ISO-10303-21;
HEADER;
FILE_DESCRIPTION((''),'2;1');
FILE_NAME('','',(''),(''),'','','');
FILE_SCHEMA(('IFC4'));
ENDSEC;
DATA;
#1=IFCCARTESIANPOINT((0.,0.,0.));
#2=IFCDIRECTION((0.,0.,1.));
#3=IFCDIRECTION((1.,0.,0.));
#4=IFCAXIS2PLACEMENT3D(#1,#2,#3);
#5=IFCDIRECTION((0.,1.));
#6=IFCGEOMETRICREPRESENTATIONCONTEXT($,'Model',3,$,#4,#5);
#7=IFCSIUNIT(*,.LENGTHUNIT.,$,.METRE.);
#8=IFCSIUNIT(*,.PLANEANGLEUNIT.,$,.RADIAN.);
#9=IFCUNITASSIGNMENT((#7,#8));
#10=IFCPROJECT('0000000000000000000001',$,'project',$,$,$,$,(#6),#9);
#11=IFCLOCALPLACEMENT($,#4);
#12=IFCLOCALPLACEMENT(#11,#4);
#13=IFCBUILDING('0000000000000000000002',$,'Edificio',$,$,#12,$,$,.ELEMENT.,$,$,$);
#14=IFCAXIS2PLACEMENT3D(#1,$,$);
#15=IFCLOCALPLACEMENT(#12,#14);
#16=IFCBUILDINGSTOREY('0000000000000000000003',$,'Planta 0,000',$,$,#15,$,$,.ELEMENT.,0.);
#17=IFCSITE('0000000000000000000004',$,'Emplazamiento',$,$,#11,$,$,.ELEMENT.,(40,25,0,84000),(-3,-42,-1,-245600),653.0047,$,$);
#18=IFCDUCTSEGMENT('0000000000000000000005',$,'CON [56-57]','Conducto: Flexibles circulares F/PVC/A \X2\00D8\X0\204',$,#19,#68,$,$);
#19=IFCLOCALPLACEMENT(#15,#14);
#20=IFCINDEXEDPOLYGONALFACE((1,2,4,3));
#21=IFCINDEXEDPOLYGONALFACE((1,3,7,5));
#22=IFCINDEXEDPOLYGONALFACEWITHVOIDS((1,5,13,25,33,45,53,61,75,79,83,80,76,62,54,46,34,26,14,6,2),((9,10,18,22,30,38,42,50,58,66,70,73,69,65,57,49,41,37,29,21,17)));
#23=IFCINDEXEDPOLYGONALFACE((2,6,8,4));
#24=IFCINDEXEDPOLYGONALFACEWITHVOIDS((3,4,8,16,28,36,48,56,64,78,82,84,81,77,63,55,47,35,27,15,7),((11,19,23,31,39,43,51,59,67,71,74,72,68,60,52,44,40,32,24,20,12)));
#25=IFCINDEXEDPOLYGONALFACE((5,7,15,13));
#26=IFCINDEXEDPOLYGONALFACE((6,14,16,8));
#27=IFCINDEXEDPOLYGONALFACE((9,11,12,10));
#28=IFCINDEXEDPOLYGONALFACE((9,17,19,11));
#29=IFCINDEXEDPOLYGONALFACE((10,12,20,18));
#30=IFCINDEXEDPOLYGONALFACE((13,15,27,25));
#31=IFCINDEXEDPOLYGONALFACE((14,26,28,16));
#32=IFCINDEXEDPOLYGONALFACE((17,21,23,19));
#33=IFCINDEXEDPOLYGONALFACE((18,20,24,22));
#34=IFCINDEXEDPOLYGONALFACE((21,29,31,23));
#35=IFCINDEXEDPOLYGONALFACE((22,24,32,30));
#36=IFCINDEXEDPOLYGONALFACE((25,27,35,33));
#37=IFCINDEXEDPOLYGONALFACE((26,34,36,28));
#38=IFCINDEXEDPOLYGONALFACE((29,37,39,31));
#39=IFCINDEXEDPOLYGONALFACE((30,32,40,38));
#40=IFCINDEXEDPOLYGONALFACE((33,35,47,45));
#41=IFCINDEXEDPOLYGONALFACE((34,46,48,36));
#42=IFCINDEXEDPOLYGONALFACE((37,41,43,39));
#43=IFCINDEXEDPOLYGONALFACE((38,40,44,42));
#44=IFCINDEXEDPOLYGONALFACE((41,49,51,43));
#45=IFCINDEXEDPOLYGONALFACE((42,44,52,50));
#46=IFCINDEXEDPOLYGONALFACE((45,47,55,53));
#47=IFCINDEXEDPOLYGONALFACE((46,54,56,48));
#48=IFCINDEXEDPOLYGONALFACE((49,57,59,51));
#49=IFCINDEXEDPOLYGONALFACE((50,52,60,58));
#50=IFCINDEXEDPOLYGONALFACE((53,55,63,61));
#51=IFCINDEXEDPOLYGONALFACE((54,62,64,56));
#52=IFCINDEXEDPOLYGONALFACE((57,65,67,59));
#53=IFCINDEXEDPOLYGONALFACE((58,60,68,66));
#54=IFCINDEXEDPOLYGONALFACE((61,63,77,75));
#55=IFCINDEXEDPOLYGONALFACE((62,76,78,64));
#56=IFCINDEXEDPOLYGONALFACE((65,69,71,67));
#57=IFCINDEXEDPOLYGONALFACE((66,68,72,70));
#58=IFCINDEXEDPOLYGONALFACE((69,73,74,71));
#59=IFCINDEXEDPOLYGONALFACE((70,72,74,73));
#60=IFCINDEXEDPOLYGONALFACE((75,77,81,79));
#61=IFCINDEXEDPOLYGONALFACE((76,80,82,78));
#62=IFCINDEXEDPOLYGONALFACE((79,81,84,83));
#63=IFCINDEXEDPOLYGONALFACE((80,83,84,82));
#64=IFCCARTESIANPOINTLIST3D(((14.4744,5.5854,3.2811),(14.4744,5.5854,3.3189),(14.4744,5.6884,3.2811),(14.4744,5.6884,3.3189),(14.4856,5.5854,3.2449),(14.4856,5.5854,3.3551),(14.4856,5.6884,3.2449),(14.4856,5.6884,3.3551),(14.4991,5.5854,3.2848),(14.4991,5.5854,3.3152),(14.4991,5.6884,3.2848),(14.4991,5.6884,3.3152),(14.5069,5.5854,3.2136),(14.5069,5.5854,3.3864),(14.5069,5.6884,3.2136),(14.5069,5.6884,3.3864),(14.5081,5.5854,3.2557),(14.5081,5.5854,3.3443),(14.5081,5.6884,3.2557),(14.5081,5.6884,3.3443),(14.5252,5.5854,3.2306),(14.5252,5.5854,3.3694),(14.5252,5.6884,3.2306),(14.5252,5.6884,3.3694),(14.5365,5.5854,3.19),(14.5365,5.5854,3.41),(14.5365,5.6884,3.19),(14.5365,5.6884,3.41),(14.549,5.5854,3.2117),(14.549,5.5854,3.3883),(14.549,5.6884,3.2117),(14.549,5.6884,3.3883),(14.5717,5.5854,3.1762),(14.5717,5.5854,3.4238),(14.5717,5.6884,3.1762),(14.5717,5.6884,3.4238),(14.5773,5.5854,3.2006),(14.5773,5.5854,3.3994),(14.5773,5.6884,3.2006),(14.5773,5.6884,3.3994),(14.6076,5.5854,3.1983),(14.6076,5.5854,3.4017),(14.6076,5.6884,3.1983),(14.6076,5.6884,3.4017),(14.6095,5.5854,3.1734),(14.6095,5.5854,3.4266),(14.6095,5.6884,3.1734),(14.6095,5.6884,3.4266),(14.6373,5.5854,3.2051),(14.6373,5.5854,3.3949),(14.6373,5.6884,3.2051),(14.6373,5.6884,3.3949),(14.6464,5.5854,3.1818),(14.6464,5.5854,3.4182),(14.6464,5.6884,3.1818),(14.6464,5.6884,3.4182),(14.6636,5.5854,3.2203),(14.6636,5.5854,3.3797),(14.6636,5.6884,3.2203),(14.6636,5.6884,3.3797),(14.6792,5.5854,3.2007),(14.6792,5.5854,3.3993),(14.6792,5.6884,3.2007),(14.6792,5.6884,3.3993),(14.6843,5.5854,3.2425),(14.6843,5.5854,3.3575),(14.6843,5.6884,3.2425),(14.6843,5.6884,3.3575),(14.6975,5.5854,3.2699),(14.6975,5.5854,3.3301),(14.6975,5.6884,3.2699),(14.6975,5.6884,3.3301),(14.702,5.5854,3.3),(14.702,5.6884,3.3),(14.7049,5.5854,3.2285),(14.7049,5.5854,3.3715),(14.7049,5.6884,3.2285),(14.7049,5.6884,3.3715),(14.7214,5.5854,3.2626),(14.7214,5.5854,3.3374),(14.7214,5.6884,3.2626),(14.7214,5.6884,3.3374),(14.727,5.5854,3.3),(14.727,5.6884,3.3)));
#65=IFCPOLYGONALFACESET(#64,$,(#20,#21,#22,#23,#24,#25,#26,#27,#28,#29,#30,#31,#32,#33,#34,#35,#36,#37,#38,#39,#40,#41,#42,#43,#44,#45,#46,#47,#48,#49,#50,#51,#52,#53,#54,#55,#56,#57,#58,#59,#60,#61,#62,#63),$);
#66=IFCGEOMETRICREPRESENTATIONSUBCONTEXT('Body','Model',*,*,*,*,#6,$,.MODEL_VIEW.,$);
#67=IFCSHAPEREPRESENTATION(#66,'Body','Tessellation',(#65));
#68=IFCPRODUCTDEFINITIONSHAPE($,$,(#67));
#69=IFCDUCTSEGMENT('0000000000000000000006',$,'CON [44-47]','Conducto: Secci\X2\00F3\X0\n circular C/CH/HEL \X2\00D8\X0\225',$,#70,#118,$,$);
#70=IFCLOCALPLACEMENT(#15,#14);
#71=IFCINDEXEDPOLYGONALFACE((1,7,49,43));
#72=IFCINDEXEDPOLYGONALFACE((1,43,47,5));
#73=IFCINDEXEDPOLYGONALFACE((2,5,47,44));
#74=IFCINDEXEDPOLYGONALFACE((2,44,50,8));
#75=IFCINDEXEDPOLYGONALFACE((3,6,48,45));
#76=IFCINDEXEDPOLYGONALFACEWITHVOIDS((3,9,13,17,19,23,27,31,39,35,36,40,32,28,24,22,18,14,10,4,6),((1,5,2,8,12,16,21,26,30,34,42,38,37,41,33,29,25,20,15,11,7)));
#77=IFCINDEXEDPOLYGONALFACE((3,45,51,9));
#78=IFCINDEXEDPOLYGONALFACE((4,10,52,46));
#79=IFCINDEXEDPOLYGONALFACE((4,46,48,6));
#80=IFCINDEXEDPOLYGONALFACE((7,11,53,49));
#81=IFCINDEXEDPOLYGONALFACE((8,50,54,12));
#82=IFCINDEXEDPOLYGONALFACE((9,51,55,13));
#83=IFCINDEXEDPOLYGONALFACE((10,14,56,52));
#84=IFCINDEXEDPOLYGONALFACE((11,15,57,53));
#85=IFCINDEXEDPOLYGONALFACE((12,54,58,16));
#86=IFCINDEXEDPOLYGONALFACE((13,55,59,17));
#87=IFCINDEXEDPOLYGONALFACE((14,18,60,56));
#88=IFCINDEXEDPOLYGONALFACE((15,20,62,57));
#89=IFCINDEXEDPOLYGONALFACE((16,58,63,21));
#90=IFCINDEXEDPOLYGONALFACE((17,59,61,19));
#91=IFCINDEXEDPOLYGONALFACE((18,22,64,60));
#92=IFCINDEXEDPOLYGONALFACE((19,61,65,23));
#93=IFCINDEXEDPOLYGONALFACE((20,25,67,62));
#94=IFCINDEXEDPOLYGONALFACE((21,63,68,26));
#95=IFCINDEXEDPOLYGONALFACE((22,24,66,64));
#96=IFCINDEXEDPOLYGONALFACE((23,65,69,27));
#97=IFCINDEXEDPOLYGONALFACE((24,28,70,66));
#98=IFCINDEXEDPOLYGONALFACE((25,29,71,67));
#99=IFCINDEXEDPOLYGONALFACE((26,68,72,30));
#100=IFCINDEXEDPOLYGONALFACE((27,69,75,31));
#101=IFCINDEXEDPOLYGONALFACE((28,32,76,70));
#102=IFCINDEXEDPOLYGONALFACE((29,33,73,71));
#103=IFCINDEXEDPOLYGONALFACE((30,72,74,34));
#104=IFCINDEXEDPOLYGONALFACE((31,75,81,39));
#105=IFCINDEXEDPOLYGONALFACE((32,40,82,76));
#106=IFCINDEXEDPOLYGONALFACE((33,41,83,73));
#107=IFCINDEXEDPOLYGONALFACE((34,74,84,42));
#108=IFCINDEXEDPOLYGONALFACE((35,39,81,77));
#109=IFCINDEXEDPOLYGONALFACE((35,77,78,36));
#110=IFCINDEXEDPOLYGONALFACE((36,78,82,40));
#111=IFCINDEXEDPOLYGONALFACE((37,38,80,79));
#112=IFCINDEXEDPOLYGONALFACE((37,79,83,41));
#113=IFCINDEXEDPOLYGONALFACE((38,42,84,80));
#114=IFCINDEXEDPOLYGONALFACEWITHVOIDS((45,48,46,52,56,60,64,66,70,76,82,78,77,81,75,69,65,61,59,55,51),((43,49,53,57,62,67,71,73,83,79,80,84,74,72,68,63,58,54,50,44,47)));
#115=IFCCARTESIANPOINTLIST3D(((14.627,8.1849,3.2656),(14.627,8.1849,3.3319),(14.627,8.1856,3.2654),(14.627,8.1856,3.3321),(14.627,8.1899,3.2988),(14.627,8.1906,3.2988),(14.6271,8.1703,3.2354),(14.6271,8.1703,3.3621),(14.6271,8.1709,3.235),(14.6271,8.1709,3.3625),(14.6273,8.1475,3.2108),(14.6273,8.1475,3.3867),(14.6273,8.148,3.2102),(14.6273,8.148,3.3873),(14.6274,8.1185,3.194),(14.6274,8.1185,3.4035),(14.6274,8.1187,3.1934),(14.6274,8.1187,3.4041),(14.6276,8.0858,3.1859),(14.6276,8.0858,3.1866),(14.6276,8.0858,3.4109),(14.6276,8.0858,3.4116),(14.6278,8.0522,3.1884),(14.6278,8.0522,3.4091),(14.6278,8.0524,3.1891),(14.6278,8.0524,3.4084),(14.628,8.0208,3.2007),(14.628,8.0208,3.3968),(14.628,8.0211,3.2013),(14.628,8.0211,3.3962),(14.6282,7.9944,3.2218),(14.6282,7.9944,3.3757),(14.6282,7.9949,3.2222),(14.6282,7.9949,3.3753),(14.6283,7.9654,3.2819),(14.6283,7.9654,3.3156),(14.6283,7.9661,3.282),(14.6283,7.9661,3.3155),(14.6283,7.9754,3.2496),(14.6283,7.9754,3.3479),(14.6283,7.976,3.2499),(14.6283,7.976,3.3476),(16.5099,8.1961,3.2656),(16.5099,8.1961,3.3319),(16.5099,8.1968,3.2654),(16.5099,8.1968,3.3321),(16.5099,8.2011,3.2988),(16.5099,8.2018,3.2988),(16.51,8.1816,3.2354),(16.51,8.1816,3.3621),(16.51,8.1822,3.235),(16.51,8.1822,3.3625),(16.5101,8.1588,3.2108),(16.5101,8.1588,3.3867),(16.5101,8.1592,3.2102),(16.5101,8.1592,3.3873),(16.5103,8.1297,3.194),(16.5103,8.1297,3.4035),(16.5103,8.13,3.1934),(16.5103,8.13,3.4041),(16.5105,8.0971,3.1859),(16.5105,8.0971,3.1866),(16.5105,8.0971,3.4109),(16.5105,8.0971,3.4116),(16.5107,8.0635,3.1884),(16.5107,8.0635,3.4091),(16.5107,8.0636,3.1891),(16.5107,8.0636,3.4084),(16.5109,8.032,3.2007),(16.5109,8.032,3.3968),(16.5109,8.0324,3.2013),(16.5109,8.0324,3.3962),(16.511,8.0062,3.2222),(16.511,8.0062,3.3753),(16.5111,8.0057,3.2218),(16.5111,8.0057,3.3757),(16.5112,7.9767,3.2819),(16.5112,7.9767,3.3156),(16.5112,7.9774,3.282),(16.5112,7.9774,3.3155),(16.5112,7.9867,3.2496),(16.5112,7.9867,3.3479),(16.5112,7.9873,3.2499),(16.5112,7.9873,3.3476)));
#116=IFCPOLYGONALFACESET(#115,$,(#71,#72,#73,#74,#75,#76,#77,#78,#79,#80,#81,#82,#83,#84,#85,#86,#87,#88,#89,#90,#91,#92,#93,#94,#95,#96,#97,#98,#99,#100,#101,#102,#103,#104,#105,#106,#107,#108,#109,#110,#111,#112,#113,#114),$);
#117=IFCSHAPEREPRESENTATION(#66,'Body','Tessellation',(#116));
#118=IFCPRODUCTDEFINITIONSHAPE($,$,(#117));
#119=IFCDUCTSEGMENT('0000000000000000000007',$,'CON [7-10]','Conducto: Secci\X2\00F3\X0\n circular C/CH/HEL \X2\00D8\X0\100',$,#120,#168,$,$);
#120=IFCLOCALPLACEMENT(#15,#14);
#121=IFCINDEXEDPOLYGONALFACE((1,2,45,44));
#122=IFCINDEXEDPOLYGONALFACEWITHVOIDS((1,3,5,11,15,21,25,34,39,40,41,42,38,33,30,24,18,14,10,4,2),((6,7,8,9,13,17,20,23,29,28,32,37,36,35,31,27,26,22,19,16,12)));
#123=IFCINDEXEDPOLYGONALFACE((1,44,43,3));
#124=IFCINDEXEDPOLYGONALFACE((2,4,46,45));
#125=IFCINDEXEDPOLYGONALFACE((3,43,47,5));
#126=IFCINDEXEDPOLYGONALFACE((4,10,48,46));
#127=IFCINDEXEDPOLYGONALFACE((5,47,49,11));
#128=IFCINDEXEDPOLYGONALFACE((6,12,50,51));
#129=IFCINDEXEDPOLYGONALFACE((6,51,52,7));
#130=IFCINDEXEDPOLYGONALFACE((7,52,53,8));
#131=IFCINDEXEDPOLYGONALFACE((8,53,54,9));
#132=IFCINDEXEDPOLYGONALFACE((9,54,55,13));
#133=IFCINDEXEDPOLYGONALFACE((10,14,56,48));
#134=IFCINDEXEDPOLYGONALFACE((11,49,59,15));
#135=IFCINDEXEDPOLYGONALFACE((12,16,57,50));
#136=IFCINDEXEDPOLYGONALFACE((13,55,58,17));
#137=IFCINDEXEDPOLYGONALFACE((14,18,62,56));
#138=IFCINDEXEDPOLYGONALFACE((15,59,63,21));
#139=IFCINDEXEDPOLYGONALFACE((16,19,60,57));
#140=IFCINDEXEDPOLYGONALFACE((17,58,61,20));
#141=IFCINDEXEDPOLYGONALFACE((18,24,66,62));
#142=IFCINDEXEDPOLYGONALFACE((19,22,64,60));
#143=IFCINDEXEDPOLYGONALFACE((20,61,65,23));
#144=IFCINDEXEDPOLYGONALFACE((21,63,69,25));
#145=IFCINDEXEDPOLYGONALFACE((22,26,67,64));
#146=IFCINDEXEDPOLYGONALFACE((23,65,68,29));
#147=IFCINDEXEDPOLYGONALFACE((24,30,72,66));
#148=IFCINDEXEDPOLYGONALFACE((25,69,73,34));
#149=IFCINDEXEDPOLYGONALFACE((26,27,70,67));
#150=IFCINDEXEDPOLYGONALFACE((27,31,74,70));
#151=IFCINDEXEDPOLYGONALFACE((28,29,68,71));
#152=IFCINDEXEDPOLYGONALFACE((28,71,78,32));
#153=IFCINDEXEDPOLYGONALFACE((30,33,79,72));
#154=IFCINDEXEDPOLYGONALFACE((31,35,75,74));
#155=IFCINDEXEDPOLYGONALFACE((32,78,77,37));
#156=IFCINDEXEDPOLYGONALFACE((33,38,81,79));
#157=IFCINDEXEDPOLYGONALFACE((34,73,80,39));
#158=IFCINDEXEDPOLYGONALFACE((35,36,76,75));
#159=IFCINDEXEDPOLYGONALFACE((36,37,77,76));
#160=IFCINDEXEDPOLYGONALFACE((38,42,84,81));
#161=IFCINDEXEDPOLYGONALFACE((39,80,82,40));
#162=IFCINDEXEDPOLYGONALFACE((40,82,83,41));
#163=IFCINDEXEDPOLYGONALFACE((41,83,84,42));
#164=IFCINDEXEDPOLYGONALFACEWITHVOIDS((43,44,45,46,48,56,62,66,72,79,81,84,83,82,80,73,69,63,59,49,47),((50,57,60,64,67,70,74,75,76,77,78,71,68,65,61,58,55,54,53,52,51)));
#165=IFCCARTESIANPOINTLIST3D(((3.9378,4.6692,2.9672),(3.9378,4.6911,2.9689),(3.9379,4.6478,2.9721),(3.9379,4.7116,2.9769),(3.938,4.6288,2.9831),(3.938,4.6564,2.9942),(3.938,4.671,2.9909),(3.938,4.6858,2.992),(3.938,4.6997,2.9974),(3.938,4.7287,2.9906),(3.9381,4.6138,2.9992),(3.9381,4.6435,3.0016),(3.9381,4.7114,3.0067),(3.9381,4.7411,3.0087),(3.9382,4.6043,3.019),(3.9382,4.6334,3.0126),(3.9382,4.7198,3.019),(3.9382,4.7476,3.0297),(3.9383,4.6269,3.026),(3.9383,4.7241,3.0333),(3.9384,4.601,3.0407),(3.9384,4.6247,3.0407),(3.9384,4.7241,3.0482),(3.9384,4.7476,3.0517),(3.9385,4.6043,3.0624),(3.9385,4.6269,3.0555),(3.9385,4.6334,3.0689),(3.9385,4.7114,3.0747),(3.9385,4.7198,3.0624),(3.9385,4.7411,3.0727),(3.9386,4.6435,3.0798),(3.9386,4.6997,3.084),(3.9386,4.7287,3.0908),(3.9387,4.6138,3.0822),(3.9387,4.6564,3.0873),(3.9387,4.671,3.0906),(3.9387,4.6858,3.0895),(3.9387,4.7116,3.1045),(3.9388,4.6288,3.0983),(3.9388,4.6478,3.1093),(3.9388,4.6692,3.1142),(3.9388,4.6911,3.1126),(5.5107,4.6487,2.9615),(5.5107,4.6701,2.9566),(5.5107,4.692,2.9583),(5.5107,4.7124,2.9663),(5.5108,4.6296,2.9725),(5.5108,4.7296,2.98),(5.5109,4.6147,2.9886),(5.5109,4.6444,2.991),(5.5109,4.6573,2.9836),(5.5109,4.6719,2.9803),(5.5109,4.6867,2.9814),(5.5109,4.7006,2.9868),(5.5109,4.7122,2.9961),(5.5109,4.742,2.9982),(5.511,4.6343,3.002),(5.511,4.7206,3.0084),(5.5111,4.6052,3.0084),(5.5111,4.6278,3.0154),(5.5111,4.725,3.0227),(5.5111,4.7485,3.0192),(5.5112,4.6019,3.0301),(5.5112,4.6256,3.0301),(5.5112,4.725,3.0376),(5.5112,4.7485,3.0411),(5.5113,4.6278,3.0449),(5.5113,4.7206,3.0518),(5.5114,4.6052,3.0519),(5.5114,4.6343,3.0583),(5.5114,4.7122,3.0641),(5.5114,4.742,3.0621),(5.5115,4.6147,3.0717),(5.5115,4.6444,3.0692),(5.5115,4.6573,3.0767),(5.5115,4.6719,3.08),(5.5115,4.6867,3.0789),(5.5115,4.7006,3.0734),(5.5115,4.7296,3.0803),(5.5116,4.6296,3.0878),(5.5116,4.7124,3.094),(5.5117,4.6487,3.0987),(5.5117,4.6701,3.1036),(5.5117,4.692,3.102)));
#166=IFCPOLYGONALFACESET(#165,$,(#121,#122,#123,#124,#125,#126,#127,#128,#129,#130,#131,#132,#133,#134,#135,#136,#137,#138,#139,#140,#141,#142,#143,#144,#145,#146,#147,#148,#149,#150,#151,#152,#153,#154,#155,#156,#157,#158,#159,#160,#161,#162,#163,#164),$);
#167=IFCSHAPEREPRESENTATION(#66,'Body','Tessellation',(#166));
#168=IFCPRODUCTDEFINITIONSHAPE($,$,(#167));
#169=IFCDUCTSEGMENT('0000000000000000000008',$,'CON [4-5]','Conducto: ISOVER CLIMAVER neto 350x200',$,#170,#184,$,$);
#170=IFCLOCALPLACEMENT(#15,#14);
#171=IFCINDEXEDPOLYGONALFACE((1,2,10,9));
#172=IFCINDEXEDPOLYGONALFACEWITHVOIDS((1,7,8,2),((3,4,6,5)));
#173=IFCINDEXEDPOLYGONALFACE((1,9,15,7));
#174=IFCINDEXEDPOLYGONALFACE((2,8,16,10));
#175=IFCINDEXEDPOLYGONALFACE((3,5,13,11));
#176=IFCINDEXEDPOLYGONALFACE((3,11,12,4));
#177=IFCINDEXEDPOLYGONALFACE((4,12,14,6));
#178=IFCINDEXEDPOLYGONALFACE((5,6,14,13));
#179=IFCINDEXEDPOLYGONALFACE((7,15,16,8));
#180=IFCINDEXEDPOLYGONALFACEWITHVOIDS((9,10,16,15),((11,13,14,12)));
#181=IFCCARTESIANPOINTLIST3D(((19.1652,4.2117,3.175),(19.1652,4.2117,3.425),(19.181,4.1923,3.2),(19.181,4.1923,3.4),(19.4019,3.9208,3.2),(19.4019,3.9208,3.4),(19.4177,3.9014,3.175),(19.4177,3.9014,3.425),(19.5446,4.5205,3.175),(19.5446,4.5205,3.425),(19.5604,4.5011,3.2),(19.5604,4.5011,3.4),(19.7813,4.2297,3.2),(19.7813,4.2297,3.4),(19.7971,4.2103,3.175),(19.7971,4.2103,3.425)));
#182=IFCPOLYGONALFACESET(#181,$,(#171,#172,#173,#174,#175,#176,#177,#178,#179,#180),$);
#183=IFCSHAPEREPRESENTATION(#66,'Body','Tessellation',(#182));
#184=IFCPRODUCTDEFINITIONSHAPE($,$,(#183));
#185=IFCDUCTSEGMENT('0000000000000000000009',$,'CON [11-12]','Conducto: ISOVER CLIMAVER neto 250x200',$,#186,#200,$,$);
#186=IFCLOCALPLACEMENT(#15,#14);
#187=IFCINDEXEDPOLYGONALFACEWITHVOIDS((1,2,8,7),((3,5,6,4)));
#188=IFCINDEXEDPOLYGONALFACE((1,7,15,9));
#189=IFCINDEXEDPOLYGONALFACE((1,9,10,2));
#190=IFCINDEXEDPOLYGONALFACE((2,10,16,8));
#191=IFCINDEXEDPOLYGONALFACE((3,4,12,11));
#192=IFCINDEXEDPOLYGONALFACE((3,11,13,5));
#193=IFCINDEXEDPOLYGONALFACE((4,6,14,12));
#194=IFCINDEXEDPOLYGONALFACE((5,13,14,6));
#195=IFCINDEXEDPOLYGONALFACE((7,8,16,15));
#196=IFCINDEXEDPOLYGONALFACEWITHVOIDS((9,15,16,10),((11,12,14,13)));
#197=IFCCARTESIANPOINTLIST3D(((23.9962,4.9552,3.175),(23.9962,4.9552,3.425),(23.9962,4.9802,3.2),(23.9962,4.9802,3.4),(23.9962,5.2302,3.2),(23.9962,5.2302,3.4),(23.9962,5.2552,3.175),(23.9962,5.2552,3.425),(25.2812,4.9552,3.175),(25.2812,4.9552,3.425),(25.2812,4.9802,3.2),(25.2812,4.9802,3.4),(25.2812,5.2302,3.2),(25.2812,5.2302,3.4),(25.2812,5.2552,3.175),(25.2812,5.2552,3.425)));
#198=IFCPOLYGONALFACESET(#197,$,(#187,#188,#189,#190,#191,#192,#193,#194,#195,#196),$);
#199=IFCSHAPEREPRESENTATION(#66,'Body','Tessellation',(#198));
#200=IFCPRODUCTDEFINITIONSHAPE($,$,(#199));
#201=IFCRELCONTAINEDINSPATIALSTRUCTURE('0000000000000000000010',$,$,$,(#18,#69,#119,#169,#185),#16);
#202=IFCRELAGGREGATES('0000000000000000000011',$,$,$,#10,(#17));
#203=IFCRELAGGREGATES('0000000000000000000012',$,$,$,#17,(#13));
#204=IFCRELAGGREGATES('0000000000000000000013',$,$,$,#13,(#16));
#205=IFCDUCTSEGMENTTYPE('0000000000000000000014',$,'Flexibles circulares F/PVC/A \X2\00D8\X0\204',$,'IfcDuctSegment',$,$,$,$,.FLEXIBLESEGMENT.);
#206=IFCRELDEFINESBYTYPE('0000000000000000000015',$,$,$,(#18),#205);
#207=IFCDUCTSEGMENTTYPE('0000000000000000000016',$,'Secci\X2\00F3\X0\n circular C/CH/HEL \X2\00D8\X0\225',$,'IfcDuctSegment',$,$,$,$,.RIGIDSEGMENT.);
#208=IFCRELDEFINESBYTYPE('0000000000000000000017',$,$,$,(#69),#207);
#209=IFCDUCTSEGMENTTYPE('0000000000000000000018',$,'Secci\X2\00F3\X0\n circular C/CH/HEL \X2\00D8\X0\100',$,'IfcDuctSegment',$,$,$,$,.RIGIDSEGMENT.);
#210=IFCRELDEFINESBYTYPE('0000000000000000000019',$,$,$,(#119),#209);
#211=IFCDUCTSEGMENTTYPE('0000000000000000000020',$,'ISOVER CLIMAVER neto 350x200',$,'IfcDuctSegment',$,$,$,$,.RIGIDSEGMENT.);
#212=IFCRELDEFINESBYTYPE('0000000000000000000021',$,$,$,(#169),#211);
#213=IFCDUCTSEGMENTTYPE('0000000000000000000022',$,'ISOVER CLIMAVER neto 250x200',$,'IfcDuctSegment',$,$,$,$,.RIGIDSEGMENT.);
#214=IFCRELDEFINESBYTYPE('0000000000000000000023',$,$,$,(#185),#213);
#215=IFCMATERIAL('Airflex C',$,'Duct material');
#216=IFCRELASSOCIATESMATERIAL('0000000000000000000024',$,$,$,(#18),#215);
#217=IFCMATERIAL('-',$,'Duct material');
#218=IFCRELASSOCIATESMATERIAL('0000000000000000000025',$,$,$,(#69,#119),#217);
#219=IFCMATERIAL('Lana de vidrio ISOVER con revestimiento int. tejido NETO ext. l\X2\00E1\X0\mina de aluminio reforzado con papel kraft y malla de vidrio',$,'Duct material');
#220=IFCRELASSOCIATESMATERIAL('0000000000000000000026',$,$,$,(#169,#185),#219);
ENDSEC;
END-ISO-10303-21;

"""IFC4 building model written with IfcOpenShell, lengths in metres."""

from ifc_helpers import new_model, si_unit, direction, frame, origin, origin_with_axes, origin_2d_with_axis, place, context, subcontext, project, spatial, hollow_rectangle, hollow_circle, extrude, material, type_object, element, save


model = new_model("IFC4")

# Units and contexts
model_context = context("Model", 3, world=origin_with_axes(), true_north=direction((0.0, 1.0)))
body_context = subcontext(model_context, "Body", "Model", "MODEL_VIEW")
ifc_project = project(units=[si_unit("LENGTHUNIT", "METRE"), si_unit("PLANEANGLEUNIT", "RADIAN")], contexts=[model_context])

# Site, building, storey
site_placement = place(None, origin_with_axes())
site = spatial("IfcSite", under=ifc_project, at=site_placement, Name="Emplazamiento", CompositionType="ELEMENT", RefLatitude=(40, 25, 0, 84000), RefLongitude=(-3, -42, -1, -245600), RefElevation=653.0047)
building_placement = place(site_placement, origin_with_axes())
building = spatial("IfcBuilding", under=site, at=building_placement, Name="Edificio", CompositionType="ELEMENT")
storey_placement = place(building_placement, origin())
storey = spatial("IfcBuildingStorey", under=building, at=storey_placement, Name="Planta 0,000", CompositionType="ELEMENT", Elevation=0.0)

# Shared definitions
ifc_material_1 = material(Name="-", Category="Duct material")

# Shared definitions
ifc_material_2 = material(Name="Lana de vidrio ISOVER con revestimiento int. tejido NETO ext. lámina de aluminio reforzado con papel kraft y malla de vidrio", Category="Duct material")

# Duct segments
ifc_material_3 = material(Name="Airflex C", Category="Duct material")
duct_segment_type_1 = type_object("IfcDuctSegmentType", Name="Flexibles circulares F/PVC/A Ø204", ApplicableOccurrence="IfcDuctSegment", PredefinedType="FLEXIBLESEGMENT")
duct_segment_1_placement = place(storey_placement, origin_with_axes())
element("IfcDuctSegment", 1, at=duct_segment_1_placement, inside=storey, type_object=duct_segment_type_1, material=ifc_material_3, Name="CON [56-57]", Description="Conducto: Flexibles circulares F/PVC/A Ø204", context=body_context, shape_type="SweptSolid", body=[
    extrude(hollow_circle(Radius=0.127, WallThickness=0.025, at=origin_2d_with_axis()), frame((14.6, 5.6884, 3.3), z_axis=(0.0, -1.0, 0.0), x_axis=(1.0, 0.0, 0.0)), (0.0, 0.0, 1.0), 0.103),
])
duct_segment_type_2 = type_object("IfcDuctSegmentType", Name="Sección circular C/CH/HEL Ø225", ApplicableOccurrence="IfcDuctSegment", PredefinedType="RIGIDSEGMENT")
duct_segment_2_placement = place(storey_placement, origin_with_axes())
element("IfcDuctSegment", 2, at=duct_segment_2_placement, inside=storey, type_object=duct_segment_type_2, material=ifc_material_1, Name="CON [44-47]", Description="Conducto: Sección circular C/CH/HEL Ø225", context=body_context, shape_type="SweptSolid", body=[
    extrude(hollow_circle(Radius=0.1132, WallThickness=0.0007, at=origin_2d_with_axis()), frame((14.6277, 8.0774, 3.2988), z_axis=(0.999982, 0.005983, 0.0), x_axis=(-0.005983, 0.999982, 0.0)), (0.0, 0.0, 1.0), 1.8829),
])
duct_segment_type_3 = type_object("IfcDuctSegmentType", Name="Sección circular C/CH/HEL Ø100", ApplicableOccurrence="IfcDuctSegment", PredefinedType="RIGIDSEGMENT")
duct_segment_3_placement = place(storey_placement, origin_with_axes())
element("IfcDuctSegment", 3, at=duct_segment_3_placement, inside=storey, type_object=duct_segment_type_3, material=ifc_material_1, Name="CON [7-10]", Description="Conducto: Sección circular C/CH/HEL Ø100", context=body_context, shape_type="SweptSolid", body=[
    extrude(hollow_circle(Radius=0.0737, WallThickness=0.0237, at=origin_2d_with_axis()), frame((5.5112, 4.6756, 3.0301), z_axis=(-0.999977, -0.000565, 0.006729), x_axis=(0.000565, -1.0, 0.0)), (0.0, 0.0, 1.0), 1.5729),
])
duct_segment_type_4 = type_object("IfcDuctSegmentType", Name="ISOVER CLIMAVER neto 350x200", ApplicableOccurrence="IfcDuctSegment", PredefinedType="RIGIDSEGMENT")
duct_segment_4_placement = place(storey_placement, origin_with_axes())
element("IfcDuctSegment", 4, at=duct_segment_4_placement, inside=storey, type_object=duct_segment_type_4, material=ifc_material_2, Name="CON [4-5]", Description="Conducto: ISOVER CLIMAVER neto 350x200", context=body_context, shape_type="SweptSolid", body=[
    extrude(hollow_rectangle(XDim=0.4, YDim=0.25, WallThickness=0.025, at=origin_2d_with_axis()), frame((19.2915, 4.0566, 3.3), z_axis=(0.775547, 0.63129, 0.0), x_axis=(-0.63129, 0.775547, 0.0)), (0.0, 0.0, 1.0), 0.4892),
])
duct_segment_type_5 = type_object("IfcDuctSegmentType", Name="ISOVER CLIMAVER neto 250x200", ApplicableOccurrence="IfcDuctSegment", PredefinedType="RIGIDSEGMENT")
duct_segment_5_placement = place(storey_placement, origin_with_axes())
element("IfcDuctSegment", 5, at=duct_segment_5_placement, inside=storey, type_object=duct_segment_type_5, material=ifc_material_2, Name="CON [11-12]", Description="Conducto: ISOVER CLIMAVER neto 250x200", context=body_context, shape_type="SweptSolid", body=[
    extrude(hollow_rectangle(XDim=0.3, YDim=0.25, WallThickness=0.025, at=origin_2d_with_axis()), frame((23.9962, 5.1052, 3.3), z_axis=(1.0, 0.0, 0.0), x_axis=(0.0, 1.0, 0.0)), (0.0, 0.0, 1.0), 1.285),
])

save(model, "model.ifc")
